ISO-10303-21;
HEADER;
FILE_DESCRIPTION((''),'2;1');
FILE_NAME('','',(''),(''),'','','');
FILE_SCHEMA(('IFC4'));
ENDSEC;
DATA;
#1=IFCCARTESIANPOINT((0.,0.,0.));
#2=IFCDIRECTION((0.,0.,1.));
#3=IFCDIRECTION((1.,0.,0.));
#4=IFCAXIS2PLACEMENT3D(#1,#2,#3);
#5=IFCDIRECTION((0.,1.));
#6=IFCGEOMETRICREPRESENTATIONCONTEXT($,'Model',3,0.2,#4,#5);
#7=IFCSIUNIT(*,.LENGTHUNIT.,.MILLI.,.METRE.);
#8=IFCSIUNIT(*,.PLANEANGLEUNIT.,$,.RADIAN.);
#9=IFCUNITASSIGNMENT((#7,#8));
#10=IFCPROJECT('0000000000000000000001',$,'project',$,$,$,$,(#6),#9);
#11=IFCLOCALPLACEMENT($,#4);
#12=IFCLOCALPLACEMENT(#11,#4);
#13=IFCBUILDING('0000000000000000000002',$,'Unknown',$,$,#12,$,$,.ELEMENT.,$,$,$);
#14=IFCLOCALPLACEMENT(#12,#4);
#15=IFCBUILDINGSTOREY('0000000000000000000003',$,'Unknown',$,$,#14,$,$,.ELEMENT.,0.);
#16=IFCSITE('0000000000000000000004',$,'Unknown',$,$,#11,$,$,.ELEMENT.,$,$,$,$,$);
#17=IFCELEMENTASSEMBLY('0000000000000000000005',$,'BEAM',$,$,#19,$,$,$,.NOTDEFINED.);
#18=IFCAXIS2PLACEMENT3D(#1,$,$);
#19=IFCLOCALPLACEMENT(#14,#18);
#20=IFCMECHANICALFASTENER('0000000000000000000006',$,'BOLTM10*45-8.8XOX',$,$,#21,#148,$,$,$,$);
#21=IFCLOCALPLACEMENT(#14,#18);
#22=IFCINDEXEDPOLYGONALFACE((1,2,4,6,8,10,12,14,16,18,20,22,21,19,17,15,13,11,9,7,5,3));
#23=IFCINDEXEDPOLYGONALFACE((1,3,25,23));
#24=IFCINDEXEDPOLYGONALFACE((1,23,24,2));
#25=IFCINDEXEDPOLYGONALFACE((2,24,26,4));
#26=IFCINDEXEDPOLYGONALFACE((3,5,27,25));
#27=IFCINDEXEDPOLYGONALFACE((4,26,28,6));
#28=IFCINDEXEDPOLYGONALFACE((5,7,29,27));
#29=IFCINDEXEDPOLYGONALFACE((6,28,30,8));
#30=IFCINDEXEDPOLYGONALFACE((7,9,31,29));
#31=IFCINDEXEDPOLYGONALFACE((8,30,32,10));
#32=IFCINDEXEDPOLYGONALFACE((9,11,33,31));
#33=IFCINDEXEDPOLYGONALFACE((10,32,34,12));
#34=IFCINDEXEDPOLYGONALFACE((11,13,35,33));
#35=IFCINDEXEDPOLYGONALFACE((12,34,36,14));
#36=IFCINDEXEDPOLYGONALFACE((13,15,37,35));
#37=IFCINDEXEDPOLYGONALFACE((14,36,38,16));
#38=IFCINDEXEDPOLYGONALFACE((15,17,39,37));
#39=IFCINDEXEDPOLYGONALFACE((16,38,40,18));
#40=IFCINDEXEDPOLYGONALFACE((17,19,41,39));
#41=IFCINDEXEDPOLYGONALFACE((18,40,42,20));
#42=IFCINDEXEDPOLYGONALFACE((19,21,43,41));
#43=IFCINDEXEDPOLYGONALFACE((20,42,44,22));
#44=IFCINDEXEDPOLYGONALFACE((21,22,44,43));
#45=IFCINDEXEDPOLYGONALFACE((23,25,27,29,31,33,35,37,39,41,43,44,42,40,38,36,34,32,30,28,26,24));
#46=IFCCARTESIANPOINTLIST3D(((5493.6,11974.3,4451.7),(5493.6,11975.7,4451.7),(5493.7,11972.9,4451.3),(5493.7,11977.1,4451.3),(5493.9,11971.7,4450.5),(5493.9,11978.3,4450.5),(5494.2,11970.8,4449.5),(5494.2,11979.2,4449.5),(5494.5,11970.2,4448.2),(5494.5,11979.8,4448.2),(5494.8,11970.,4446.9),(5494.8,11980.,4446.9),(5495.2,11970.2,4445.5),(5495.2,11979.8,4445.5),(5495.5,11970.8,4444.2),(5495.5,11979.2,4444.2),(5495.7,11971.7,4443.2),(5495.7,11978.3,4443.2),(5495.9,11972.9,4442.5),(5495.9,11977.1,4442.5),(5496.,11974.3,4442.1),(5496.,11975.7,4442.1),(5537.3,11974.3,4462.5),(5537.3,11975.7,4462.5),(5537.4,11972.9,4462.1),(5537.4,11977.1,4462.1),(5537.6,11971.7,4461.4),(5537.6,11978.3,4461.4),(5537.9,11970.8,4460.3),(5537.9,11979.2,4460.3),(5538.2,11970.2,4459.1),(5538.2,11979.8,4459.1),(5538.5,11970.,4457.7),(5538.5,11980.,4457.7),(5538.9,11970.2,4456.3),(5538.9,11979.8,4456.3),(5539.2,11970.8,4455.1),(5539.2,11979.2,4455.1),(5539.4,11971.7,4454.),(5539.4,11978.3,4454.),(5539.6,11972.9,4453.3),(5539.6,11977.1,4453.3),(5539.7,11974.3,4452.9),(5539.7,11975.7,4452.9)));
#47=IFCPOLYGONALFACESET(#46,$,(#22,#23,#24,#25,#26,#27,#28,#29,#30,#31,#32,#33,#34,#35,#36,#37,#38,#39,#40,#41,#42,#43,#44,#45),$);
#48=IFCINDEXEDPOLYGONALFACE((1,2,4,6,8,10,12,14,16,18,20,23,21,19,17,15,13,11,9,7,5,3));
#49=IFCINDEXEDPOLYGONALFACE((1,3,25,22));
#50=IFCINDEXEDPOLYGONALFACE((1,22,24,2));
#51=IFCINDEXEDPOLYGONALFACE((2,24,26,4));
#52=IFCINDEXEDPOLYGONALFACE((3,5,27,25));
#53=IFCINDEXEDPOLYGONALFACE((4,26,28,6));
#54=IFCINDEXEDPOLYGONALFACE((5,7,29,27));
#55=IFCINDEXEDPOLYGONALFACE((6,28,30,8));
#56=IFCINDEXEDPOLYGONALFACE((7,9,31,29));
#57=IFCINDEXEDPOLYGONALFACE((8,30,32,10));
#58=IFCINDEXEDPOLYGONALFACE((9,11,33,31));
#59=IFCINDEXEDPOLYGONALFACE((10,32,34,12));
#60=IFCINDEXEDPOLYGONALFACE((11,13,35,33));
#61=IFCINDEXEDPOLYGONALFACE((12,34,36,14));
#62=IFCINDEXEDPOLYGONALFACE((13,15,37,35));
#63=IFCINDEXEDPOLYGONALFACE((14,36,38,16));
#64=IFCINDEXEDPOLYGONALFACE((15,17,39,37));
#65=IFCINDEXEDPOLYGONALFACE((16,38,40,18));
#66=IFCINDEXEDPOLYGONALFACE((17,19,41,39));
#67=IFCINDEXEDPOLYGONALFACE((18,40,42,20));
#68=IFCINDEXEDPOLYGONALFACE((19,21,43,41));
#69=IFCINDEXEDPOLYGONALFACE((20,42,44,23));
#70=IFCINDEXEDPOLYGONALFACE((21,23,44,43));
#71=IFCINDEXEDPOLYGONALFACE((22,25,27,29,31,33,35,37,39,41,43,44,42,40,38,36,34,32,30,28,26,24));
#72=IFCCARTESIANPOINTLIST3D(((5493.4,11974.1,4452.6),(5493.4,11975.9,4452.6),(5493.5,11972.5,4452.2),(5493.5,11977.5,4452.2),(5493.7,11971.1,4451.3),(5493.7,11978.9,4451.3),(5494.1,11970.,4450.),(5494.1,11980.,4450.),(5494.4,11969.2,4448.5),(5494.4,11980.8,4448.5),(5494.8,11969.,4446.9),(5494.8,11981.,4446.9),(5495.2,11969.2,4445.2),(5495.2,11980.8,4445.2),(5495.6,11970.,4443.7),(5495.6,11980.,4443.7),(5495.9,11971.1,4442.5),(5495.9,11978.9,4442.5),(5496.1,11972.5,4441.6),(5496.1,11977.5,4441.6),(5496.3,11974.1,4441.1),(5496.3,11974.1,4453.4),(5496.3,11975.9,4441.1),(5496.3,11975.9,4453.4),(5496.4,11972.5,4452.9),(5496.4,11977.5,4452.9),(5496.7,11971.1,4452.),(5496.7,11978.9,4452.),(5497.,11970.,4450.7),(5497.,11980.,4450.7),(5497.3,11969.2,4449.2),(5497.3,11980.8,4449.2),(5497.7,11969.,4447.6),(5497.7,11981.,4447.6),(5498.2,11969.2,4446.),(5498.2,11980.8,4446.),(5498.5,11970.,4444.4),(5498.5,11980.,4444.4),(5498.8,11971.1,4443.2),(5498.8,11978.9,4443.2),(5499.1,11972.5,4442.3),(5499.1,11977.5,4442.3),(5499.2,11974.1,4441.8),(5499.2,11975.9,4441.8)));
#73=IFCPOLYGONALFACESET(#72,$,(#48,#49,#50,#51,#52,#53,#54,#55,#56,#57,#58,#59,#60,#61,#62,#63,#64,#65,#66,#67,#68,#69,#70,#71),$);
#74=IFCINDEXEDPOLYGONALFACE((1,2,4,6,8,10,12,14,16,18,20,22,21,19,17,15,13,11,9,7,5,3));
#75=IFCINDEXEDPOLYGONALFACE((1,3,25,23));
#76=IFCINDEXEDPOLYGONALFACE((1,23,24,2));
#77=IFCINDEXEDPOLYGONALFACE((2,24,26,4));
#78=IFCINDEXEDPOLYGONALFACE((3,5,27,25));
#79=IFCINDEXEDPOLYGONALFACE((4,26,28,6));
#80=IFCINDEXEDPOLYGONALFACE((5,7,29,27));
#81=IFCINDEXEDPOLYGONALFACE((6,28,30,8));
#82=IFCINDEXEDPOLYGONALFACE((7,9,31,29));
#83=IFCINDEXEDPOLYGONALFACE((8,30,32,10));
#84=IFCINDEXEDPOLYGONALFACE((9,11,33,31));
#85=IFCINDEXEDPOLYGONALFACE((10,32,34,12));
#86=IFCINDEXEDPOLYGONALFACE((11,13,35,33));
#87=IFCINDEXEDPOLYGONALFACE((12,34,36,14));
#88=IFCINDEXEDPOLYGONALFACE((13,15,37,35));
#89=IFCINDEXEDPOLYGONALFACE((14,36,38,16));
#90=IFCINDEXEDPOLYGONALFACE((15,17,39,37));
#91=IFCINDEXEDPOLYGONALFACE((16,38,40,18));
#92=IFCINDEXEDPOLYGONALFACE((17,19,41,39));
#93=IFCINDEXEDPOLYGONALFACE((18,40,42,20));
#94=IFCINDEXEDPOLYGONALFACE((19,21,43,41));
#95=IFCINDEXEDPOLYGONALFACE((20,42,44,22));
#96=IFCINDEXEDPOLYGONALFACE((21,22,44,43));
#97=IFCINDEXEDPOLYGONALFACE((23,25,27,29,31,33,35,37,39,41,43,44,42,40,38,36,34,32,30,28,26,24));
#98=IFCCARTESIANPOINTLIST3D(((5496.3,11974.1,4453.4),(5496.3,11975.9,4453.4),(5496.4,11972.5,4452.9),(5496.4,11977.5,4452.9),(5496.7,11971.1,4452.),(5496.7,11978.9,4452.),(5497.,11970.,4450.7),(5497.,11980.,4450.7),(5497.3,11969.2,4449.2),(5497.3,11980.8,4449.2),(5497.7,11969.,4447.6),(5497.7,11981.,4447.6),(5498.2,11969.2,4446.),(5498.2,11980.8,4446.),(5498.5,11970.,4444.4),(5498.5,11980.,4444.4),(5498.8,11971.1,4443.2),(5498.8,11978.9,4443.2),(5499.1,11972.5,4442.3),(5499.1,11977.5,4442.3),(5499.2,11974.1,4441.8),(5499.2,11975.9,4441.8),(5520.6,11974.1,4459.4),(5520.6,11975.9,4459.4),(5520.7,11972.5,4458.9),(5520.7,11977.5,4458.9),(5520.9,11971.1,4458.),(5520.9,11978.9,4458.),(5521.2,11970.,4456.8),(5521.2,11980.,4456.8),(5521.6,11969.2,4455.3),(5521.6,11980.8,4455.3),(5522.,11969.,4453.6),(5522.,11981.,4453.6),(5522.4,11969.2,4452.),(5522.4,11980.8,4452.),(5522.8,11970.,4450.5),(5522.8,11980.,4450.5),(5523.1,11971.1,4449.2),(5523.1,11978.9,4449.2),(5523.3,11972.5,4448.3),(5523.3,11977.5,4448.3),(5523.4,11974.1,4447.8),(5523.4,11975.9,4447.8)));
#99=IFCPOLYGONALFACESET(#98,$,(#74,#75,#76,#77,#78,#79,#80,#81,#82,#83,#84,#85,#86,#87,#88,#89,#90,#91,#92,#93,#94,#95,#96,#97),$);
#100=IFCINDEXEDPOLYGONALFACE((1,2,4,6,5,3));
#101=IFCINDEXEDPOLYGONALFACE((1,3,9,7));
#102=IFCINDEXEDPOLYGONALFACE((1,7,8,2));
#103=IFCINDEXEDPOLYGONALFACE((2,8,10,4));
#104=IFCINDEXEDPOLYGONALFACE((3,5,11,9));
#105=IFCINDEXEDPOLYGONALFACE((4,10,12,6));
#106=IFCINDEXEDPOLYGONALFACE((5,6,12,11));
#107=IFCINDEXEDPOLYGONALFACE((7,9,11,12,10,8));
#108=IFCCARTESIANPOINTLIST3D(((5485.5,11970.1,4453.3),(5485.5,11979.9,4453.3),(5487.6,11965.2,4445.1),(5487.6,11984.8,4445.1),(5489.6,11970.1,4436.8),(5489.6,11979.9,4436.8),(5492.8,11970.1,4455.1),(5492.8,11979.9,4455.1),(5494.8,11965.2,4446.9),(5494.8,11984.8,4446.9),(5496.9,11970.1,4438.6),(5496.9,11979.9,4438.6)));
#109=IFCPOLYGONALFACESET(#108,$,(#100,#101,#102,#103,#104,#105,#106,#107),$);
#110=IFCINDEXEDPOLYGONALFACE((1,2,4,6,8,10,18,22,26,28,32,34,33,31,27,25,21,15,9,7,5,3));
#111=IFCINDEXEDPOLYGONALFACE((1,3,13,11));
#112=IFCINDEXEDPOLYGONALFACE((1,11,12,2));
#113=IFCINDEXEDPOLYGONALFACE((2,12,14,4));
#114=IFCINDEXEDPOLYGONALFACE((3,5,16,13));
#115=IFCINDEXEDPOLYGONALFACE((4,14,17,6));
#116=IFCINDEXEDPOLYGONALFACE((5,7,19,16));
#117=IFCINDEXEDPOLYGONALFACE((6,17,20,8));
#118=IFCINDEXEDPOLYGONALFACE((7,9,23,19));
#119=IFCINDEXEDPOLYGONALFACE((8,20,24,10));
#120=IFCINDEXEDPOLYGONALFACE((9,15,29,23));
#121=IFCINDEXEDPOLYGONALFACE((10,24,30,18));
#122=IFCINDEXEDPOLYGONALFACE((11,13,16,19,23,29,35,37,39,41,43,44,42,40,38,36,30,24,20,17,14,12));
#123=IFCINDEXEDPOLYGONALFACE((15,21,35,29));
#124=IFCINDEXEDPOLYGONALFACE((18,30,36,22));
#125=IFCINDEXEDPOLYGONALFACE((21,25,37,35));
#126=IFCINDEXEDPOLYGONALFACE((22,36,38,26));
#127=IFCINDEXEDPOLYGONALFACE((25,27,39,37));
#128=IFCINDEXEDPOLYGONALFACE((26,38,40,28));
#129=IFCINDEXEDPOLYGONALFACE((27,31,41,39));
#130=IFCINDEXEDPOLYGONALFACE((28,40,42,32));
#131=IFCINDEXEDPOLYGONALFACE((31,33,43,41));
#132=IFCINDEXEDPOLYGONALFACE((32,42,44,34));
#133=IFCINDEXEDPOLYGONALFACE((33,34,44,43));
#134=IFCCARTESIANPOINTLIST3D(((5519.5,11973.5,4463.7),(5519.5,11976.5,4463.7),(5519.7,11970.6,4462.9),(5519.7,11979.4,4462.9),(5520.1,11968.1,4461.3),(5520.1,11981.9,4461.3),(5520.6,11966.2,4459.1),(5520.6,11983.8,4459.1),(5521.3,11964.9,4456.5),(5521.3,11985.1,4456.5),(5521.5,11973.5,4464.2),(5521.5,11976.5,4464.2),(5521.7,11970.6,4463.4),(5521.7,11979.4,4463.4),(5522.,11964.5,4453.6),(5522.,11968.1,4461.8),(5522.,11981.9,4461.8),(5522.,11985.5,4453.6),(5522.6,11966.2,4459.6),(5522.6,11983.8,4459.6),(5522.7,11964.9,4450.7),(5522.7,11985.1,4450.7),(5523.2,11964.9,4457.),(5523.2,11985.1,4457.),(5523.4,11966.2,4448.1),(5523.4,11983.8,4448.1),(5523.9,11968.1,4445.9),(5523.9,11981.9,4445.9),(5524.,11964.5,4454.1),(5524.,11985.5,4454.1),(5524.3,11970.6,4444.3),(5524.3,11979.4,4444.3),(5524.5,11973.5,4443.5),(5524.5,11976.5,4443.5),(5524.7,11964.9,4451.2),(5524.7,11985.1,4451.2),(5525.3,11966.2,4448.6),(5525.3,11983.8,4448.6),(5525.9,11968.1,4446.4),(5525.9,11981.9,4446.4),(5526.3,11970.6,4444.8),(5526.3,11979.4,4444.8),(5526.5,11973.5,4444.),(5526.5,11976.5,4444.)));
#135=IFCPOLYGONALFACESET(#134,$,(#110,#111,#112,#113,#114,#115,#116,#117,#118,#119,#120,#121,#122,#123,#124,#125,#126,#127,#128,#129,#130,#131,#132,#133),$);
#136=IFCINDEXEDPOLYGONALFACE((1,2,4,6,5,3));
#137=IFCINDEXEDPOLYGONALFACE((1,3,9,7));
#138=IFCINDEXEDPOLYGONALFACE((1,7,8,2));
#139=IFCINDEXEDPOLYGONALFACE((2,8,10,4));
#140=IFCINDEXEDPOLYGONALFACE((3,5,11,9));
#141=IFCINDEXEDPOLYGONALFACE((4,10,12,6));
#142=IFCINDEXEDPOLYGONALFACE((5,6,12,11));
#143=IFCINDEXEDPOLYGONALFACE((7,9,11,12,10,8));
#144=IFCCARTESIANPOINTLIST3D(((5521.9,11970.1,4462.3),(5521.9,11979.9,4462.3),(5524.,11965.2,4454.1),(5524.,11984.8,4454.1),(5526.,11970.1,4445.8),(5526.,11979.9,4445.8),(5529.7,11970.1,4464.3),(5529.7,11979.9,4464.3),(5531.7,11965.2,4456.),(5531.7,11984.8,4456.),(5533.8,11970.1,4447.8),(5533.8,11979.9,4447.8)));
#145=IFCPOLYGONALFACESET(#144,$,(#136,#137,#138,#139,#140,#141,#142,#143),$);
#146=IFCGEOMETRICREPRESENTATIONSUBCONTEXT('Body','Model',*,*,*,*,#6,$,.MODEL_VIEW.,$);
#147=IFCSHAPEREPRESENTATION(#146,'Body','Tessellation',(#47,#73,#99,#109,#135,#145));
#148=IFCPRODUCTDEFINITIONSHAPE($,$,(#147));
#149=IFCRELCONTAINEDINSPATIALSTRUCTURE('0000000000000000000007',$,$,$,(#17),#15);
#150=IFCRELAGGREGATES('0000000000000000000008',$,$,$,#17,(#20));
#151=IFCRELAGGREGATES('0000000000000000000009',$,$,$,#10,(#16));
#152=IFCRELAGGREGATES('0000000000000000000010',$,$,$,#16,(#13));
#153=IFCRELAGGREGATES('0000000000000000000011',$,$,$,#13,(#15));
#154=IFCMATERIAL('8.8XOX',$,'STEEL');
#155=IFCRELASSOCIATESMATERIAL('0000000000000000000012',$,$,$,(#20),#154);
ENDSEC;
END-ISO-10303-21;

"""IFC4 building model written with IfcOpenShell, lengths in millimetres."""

from ifc_helpers import new_model, si_unit, direction, frame, origin_with_axes, place, context, subcontext, project, spatial, line, arc, indexed_curve, outline, extrude, source, transform, mapped, material, element, aggregate, save


model = new_model("IFC4")

# Units and contexts
model_context = context("Model", 3, precision=0.2, world=origin_with_axes(), true_north=direction((0.0, 1.0)))
body_context = subcontext(model_context, "Body", "Model", "MODEL_VIEW")
ifc_project = project(units=[si_unit("LENGTHUNIT", "METRE", prefix="MILLI"), si_unit("PLANEANGLEUNIT", "RADIAN")], contexts=[model_context])

# Site, building, storey
site_placement = place(None, origin_with_axes())
site = spatial("IfcSite", under=ifc_project, at=site_placement, Name="Unknown", CompositionType="ELEMENT")
building_placement = place(site_placement, origin_with_axes())
building = spatial("IfcBuilding", under=site, at=building_placement, Name="Unknown", CompositionType="ELEMENT")
storey_placement = place(building_placement, origin_with_axes())
storey = spatial("IfcBuildingStorey", under=building, at=storey_placement, Name="Unknown", CompositionType="ELEMENT", Elevation=0.0)

# Shared definitions
ifc_material_1 = material(Name="8.8XOX", Category="STEEL")

# Element assembly, mechanical fastener
shared_shape_1 = source(origin_with_axes(), body_context, "Body", "SweptSolid", [
    extrude(outline(indexed_curve([(5.0, 0.0), (0.0, 5.0), (-5.0, 0.0), (0.0, -5.0)], segments=[arc(1, 2, 3), arc(3, 4, 1)])), frame((0.0, 0.0, 3.8), z_axis=(0.0, 0.0, -1.0), x_axis=(0.0, 1.0, 0.0)), (0.0, 0.0, 1.0), 45.0),
    extrude(outline(indexed_curve([(6.0, 0.0), (0.0, 6.0), (-6.0, 0.0), (0.0, -6.0)], segments=[arc(1, 2, 3), arc(3, 4, 1)])), frame((0.0, 0.0, 3.8), z_axis=(0.0, 0.0, -1.0), x_axis=(0.0, 1.0, 0.0)), (0.0, 0.0, 1.0), 3.0),
    extrude(outline(indexed_curve([(6.0, 0.0), (0.0, 6.0), (-6.0, 0.0), (0.0, -6.0)], segments=[arc(1, 2, 3), arc(3, 4, 1)])), frame((0.0, 0.0, 0.8), z_axis=(0.0, 0.0, -1.0), x_axis=(0.0, 1.0, 0.0)), (0.0, 0.0, 1.0), 25.0),
    extrude(outline(indexed_curve([(9.8, 0.0), (4.9, 8.5), (-4.9, 8.5), (-9.8, 0.0), (-4.9, -8.5), (4.9, -8.5)], segments=[line(1, 2, 3, 4, 5, 6, 1)])), frame((0.0, 0.0, 11.2), z_axis=(0.0, 0.0, -1.0), x_axis=(0.0, 1.0, 0.0)), (0.0, 0.0, 1.0), 7.5),
    extrude(outline(indexed_curve([(10.5, 0.0), (0.0, 10.5), (-10.5, 0.0), (0.0, -10.5)], segments=[arc(1, 2, 3), arc(3, 4, 1)])), frame((0.0, 0.0, -24.2), z_axis=(0.0, 0.0, -1.0), x_axis=(0.0, 1.0, 0.0)), (0.0, 0.0, 1.0), 2.0),
    extrude(outline(indexed_curve([(9.8, 0.0), (4.9, 8.5), (-4.9, 8.5), (-9.8, 0.0), (-4.9, -8.5), (4.9, -8.5)], segments=[line(1, 2, 3, 4, 5, 6, 1)])), frame((0.0, 0.0, -26.2), z_axis=(0.0, 0.0, -1.0), x_axis=(0.0, 1.0, 0.0)), (0.0, 0.0, 1.0), 8.0),
])
assembly_1_placement = place(storey_placement, frame((5508.7, 6000.0, 4455.5), z_axis=(0.970613, 0.0, 0.240648), x_axis=(0.0, 1.0, 0.0)))
assembly_1 = element("IfcElementAssembly", 1, at=assembly_1_placement, inside=storey, Name="BEAM", PredefinedType="NOTDEFINED")
mechanical_fastener_1_placement = place(assembly_1_placement, frame((5975.0, -5.0, -11.8), z_axis=(0.0, 0.0, -1.0), x_axis=(0.0, 1.0, 0.0)))
mechanical_fastener_1 = element("IfcMechanicalFastener", 2, at=mechanical_fastener_1_placement, material=ifc_material_1, Name="BOLTM10*45-8.8XOX", context=body_context, shape_type="MappedRepresentation", body=[
    mapped(shared_shape_1, transform((0.0, 0.0, 0.0))),
])
aggregate(assembly_1, [mechanical_fastener_1])

save(model, "model.ifc")
